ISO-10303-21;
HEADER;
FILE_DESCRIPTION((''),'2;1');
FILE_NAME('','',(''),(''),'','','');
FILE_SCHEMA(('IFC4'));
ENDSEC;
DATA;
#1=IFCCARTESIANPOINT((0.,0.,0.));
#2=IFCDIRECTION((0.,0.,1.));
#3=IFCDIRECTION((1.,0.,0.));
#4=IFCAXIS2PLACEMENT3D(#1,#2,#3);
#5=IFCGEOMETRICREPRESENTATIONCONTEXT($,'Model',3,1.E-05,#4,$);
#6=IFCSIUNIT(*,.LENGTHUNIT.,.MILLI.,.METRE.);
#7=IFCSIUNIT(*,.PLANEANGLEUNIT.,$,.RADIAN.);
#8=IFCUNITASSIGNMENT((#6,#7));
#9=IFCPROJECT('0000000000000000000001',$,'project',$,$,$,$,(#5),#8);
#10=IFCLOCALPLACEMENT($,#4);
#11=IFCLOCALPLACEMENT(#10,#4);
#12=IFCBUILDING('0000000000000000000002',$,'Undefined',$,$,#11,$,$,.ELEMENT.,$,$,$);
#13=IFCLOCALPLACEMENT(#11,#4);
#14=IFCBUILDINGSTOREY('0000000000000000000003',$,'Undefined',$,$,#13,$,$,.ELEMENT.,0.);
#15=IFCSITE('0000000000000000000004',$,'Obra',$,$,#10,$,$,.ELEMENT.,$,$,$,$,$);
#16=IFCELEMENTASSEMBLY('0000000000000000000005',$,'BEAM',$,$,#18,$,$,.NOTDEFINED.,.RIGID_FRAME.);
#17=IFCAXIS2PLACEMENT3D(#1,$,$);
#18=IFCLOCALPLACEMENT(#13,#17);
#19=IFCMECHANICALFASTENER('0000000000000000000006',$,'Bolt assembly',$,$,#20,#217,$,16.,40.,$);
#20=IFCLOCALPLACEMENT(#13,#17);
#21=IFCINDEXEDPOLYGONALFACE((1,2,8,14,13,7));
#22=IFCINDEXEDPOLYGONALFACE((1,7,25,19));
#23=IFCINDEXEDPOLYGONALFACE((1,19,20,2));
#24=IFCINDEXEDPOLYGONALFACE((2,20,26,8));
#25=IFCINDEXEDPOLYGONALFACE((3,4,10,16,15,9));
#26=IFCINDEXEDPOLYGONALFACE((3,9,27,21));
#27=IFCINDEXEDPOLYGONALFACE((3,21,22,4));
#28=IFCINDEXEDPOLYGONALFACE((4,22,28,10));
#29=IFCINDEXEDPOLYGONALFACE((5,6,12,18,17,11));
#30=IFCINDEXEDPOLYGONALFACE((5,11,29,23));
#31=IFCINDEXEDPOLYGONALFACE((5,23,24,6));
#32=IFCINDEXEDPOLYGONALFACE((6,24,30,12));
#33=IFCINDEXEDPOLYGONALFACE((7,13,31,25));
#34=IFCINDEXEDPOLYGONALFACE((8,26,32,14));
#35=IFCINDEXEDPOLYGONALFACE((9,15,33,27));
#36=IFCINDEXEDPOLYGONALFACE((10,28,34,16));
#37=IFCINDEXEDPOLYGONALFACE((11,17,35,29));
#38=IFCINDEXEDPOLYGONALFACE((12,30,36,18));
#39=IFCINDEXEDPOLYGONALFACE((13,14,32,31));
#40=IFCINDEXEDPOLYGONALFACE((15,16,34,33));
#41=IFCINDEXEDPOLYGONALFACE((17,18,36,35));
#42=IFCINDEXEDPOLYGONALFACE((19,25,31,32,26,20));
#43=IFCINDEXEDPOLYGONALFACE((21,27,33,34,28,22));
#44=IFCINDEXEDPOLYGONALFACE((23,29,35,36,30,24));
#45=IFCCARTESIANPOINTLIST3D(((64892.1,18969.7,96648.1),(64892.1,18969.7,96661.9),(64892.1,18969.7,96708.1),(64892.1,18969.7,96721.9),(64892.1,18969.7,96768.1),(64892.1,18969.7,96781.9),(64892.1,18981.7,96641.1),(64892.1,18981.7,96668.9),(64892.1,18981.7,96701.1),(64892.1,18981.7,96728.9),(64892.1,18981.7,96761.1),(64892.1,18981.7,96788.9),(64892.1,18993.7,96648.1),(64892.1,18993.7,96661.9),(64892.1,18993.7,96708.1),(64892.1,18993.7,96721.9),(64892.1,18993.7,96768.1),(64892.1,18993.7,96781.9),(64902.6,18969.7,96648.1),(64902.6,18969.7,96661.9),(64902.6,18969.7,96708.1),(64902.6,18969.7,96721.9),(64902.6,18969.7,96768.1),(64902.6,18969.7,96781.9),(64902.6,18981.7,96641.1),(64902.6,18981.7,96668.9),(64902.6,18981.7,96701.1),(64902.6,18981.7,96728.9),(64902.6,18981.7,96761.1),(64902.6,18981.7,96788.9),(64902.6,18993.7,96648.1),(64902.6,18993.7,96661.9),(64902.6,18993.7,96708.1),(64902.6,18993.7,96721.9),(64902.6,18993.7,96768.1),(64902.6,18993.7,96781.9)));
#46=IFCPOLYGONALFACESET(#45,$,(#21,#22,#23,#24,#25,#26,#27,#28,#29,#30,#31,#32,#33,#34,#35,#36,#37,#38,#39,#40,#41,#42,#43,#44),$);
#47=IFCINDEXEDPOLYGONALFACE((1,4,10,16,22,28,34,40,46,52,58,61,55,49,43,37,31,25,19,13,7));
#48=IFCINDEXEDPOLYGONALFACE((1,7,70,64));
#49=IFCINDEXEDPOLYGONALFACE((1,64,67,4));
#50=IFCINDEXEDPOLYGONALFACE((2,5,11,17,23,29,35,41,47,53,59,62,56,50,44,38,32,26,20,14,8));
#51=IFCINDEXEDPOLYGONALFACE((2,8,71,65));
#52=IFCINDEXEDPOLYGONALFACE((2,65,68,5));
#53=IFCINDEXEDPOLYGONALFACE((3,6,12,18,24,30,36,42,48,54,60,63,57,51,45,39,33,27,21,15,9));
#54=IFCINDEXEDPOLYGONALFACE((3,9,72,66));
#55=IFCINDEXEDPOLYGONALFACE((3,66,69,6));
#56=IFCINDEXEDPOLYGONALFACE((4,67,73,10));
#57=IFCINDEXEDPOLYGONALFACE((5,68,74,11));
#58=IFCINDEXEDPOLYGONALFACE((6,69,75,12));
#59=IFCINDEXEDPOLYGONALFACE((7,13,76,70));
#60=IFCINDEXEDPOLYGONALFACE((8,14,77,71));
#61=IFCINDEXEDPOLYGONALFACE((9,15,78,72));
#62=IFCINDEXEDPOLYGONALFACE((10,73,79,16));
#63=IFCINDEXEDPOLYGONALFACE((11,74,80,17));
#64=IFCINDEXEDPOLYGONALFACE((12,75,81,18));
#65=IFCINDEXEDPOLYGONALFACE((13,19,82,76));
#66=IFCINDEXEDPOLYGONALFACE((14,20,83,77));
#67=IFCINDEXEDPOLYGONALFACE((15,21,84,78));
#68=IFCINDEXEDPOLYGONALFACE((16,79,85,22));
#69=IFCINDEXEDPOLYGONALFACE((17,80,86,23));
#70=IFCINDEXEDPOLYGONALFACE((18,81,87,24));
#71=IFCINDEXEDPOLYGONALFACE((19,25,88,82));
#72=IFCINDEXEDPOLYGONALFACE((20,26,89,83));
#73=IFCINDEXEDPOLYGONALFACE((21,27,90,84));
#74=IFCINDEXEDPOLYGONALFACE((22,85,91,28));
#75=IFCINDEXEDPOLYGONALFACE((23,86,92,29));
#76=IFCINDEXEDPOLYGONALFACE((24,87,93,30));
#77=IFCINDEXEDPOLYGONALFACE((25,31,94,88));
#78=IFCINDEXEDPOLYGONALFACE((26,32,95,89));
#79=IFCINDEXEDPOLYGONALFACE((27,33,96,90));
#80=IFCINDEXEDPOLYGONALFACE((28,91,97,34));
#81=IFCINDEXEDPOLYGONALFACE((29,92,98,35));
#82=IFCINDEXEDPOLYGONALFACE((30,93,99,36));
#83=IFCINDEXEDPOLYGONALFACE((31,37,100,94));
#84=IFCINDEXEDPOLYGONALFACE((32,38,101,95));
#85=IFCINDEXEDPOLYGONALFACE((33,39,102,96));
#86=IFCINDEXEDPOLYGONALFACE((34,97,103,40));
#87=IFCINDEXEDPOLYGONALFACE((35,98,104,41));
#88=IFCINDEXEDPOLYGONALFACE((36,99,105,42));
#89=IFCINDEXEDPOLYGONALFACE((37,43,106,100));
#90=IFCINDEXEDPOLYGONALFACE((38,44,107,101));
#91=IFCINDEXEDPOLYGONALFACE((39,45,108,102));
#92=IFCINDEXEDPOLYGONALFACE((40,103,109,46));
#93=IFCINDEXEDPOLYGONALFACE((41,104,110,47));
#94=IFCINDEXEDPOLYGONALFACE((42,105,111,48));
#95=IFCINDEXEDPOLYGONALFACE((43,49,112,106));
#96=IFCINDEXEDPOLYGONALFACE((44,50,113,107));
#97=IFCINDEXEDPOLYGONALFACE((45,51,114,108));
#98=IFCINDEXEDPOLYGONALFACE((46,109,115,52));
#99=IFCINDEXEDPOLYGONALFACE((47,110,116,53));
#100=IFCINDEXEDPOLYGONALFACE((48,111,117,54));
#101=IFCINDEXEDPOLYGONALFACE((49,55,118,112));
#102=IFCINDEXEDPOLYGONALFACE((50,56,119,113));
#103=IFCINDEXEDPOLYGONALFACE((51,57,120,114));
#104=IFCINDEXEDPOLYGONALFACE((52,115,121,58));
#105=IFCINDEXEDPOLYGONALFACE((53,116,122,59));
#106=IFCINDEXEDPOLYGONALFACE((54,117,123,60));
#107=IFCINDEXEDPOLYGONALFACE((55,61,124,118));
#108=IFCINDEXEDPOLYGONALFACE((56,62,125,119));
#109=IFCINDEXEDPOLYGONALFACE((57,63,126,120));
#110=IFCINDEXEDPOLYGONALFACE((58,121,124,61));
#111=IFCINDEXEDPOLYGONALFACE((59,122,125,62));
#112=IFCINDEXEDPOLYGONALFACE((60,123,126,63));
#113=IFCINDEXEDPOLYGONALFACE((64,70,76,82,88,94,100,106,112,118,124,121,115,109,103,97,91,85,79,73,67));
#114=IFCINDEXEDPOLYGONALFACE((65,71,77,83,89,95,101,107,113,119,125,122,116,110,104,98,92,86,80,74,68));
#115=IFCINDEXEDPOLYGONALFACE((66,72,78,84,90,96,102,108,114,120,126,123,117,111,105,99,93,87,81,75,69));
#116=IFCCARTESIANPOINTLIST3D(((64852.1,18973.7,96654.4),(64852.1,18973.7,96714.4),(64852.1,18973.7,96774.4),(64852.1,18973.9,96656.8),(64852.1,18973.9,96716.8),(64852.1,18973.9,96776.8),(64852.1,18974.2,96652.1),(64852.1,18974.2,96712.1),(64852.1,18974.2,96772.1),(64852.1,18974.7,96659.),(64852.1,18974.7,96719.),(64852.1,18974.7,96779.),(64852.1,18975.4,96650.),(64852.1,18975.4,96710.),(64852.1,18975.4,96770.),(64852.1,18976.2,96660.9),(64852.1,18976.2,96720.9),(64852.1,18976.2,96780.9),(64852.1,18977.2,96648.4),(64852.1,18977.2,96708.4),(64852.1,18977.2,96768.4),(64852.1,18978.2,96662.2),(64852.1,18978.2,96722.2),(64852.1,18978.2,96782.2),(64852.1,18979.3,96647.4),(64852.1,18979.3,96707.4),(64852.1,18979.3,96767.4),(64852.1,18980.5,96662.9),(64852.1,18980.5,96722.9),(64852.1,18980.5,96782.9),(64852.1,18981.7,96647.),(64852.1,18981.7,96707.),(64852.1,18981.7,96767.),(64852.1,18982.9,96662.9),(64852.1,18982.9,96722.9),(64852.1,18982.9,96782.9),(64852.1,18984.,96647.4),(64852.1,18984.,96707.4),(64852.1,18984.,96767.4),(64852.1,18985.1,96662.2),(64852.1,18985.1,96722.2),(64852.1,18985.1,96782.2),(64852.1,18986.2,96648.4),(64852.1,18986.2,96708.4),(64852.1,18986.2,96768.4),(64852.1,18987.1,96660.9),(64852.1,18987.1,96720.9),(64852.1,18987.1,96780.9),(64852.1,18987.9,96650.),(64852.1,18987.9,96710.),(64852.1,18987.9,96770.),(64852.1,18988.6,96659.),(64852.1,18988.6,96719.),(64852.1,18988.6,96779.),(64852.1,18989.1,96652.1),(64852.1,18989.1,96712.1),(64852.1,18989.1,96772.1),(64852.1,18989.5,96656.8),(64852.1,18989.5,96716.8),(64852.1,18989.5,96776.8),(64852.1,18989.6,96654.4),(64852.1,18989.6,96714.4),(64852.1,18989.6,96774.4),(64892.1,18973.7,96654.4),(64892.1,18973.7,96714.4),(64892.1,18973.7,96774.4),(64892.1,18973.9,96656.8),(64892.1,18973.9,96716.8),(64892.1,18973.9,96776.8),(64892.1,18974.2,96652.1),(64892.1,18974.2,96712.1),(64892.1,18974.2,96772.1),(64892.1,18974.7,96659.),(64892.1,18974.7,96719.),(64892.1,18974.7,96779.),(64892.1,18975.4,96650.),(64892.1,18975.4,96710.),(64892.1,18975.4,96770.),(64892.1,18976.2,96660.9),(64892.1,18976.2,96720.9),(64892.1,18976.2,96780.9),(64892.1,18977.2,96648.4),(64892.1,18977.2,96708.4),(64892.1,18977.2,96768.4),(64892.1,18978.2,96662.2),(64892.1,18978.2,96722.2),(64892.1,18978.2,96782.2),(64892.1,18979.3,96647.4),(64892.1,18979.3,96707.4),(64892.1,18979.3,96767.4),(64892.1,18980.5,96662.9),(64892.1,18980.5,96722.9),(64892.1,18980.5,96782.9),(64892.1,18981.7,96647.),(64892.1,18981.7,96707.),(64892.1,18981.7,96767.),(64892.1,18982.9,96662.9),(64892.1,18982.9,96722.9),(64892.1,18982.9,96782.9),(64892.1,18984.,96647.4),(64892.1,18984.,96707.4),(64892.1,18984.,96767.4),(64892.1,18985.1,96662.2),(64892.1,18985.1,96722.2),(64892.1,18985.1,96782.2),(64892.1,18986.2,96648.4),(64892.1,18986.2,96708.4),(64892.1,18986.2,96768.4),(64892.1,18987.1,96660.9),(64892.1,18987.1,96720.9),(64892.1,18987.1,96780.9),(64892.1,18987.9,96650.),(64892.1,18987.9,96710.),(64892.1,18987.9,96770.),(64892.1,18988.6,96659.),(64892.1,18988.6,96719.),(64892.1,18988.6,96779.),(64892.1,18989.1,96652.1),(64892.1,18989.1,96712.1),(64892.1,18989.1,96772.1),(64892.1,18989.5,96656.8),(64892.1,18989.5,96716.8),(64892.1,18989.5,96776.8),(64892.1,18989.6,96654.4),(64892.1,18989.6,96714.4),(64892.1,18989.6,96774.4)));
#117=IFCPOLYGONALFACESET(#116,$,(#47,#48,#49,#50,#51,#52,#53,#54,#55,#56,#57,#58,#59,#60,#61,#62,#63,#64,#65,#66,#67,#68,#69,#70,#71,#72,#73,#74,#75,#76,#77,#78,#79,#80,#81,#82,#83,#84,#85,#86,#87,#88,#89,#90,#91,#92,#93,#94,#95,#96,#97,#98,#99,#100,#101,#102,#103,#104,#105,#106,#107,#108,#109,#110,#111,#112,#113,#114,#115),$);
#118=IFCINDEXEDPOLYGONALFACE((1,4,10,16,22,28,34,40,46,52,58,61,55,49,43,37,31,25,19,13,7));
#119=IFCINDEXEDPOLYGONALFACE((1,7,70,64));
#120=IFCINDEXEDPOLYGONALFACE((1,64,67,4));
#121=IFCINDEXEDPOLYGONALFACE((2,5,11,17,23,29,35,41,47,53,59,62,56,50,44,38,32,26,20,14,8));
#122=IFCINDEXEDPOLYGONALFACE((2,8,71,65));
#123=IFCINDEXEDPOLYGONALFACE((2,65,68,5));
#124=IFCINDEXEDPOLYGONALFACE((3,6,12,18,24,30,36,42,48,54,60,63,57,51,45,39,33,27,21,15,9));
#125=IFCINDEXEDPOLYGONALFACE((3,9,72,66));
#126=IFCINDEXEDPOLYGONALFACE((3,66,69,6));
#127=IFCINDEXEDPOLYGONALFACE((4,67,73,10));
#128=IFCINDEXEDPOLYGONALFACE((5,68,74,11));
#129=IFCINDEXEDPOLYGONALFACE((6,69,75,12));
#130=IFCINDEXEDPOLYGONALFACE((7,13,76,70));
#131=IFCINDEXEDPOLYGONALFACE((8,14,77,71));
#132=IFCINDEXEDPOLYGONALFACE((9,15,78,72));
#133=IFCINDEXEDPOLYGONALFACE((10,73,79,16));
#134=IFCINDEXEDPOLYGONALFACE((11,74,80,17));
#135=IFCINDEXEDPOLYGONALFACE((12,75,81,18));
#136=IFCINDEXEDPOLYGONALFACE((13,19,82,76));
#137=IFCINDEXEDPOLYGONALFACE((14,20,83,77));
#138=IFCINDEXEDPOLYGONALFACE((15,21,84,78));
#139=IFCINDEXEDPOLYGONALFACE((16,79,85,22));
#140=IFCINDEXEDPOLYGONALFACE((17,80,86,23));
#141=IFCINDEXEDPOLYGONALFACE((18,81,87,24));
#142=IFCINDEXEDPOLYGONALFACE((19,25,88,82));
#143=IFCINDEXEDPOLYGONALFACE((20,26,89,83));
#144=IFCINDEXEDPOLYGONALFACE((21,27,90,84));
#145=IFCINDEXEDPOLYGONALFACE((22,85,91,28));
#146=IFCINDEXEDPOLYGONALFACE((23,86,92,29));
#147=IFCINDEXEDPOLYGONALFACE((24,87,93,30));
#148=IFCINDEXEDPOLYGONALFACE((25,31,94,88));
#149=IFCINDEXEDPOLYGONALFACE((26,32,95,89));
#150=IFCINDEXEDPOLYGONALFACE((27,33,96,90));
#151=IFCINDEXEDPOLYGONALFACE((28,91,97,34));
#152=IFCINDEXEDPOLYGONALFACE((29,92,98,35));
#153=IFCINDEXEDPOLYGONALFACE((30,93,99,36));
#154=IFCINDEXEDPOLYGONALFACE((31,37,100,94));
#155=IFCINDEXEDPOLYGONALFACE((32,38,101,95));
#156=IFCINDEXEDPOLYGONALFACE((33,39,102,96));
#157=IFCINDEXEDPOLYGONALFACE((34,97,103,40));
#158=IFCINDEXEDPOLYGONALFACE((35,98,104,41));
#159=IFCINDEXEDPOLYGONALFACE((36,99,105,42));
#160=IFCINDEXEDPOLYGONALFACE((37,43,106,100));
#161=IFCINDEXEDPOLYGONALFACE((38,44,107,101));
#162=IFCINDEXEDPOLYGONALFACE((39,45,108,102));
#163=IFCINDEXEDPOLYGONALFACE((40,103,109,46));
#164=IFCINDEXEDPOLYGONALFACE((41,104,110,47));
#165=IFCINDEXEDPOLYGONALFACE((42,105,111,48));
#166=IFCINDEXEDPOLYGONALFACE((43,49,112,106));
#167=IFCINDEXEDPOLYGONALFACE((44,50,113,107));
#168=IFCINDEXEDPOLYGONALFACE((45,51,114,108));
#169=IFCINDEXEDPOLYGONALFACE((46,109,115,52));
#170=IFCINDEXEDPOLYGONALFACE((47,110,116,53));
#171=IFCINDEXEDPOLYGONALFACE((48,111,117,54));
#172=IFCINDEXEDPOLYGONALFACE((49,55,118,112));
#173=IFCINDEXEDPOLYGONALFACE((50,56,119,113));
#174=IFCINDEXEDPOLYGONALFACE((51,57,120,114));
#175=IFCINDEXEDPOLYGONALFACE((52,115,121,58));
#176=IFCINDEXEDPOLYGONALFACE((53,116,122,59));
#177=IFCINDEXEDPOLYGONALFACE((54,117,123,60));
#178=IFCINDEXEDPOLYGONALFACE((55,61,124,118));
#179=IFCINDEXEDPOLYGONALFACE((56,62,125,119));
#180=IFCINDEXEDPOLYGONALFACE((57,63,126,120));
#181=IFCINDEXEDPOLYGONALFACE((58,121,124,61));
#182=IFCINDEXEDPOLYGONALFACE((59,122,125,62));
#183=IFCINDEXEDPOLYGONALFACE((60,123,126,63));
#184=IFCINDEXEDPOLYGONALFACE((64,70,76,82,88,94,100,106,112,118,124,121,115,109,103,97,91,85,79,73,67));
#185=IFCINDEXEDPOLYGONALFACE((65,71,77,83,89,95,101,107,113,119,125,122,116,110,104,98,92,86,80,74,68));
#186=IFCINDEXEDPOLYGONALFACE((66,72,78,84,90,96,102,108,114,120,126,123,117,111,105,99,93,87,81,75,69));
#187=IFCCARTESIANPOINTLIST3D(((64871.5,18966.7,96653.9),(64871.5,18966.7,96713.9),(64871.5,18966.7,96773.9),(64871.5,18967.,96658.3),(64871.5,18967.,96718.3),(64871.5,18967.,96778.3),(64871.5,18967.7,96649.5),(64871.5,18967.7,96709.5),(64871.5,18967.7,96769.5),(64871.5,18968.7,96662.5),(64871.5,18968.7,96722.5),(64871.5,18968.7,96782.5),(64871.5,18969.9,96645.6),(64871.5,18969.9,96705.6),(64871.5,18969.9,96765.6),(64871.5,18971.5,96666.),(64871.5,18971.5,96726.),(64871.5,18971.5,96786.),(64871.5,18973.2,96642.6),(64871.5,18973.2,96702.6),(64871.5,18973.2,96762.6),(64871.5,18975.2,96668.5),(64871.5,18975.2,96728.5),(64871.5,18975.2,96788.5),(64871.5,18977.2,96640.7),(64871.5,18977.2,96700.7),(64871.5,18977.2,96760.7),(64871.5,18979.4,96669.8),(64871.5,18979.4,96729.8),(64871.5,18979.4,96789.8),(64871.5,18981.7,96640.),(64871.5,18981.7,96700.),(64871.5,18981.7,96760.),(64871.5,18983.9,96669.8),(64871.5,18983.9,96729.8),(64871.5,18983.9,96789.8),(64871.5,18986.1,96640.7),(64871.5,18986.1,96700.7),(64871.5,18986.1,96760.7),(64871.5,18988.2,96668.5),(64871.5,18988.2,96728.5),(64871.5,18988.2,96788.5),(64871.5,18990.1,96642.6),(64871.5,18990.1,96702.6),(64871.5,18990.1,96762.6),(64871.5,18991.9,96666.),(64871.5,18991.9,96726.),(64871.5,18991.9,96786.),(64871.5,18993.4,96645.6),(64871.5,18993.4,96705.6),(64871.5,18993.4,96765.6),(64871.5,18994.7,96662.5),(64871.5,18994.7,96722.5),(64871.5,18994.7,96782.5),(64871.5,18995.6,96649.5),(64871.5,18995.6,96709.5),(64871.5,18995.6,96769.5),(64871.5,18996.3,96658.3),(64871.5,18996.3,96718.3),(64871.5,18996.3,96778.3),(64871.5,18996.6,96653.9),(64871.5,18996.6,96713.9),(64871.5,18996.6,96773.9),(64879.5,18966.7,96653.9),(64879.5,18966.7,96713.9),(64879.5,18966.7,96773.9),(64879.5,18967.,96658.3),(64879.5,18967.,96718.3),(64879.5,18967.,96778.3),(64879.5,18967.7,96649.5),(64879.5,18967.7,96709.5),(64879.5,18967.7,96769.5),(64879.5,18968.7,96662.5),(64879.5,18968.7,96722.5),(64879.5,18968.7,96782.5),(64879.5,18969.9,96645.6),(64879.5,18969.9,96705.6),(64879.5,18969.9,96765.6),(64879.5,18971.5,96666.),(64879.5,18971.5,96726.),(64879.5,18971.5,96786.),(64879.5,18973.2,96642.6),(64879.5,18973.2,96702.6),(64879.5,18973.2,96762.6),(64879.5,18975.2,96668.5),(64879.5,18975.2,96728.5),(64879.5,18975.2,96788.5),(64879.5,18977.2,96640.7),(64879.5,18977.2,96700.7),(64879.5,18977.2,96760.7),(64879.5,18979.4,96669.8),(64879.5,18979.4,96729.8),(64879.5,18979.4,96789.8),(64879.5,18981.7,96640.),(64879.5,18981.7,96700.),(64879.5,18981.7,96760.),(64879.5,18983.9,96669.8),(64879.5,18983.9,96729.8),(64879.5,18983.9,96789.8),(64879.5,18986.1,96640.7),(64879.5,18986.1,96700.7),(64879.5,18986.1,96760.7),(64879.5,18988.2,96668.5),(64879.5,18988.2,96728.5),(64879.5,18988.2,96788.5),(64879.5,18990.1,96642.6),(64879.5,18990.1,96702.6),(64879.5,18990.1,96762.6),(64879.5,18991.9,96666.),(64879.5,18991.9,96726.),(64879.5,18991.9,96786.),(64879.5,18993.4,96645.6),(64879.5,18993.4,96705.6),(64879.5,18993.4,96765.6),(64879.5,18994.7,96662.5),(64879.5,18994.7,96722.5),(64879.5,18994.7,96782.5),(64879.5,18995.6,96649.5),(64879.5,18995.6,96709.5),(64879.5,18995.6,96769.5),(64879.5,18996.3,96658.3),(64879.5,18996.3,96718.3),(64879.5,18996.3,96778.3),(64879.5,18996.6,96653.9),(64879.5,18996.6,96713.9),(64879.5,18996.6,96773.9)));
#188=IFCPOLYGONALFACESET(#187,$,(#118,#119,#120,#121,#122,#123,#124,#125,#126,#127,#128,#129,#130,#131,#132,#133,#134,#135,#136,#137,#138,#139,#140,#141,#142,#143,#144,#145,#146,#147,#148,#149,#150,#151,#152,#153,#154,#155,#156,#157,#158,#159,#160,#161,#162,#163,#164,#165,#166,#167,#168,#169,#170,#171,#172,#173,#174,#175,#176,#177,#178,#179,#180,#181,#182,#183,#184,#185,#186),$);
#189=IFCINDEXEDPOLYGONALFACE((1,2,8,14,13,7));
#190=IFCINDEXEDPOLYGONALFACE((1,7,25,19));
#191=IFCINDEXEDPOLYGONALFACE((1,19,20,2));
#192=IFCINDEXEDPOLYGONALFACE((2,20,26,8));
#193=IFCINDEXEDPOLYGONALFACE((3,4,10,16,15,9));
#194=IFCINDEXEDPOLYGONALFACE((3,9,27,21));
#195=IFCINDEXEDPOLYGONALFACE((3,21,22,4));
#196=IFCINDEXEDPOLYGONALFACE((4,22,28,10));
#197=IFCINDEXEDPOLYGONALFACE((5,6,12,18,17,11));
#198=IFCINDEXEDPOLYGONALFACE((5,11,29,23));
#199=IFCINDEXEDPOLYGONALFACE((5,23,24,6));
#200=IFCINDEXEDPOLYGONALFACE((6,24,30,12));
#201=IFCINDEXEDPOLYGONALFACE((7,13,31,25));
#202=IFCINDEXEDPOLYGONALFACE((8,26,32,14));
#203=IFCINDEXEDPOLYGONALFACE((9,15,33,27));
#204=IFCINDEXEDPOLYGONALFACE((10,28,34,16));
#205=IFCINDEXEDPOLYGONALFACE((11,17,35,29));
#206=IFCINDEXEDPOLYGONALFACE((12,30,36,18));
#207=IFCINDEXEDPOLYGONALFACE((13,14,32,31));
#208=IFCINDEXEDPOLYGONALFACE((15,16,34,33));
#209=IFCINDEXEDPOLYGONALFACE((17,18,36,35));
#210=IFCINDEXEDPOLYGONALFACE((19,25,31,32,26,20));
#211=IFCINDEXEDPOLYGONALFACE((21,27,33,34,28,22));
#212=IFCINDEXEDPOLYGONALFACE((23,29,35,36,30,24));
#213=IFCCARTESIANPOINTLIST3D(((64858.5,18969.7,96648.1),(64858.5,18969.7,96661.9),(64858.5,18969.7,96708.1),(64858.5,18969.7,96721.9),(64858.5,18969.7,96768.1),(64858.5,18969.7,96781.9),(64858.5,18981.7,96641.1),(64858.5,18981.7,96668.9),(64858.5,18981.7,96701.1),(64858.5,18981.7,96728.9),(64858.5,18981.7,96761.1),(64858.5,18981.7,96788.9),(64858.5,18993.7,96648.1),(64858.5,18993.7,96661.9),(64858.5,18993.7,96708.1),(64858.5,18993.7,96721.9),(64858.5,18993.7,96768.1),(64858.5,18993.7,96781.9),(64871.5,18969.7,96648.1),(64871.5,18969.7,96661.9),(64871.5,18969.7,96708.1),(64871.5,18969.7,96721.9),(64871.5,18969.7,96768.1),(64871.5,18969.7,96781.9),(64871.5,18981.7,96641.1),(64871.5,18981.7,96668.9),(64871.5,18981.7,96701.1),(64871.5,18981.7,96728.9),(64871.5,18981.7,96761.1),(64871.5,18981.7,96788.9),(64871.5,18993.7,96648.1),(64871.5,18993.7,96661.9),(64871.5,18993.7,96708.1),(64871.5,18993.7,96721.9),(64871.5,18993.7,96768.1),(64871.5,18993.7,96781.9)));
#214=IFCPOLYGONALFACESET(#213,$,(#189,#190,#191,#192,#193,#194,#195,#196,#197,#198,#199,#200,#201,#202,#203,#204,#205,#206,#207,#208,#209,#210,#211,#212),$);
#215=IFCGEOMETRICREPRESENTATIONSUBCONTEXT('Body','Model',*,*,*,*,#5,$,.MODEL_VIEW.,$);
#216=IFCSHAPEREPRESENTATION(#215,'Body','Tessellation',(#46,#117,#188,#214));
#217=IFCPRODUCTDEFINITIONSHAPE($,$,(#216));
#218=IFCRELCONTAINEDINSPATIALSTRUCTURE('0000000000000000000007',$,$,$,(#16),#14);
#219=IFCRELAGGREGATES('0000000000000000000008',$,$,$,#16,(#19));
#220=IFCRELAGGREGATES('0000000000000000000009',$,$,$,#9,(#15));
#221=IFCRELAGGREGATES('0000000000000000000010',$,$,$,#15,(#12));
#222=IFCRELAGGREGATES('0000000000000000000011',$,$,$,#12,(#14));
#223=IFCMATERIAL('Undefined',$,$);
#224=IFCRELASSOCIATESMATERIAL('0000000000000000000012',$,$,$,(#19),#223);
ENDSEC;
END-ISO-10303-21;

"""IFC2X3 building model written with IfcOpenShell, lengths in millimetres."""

from ifc_helpers import new_model, si_unit, frame, origin_with_axes, origin_2d_with_axis, place, context, subcontext, project, spatial, polyline, circle, outline, extrude, source, transform, mapped, material, element, aggregate, save


model = new_model("IFC2X3")

# Units and contexts
model_context = context("Model", 3, precision=1e-05, world=origin_with_axes())
body_context = subcontext(model_context, "Body", "Model", "MODEL_VIEW")
ifc_project = project(units=[si_unit("LENGTHUNIT", "METRE", prefix="MILLI"), si_unit("PLANEANGLEUNIT", "RADIAN")], contexts=[model_context])

# Site, building, storey
site_placement = place(None, origin_with_axes())
site = spatial("IfcSite", under=ifc_project, at=site_placement, Name="Obra", CompositionType="ELEMENT")
building_placement = place(site_placement, origin_with_axes())
building = spatial("IfcBuilding", under=site, at=building_placement, Name="Undefined", CompositionType="ELEMENT")
storey_placement = place(building_placement, origin_with_axes())
storey = spatial("IfcBuildingStorey", under=building, at=storey_placement, Name="Undefined", CompositionType="ELEMENT", Elevation=0.0)

# Element assembly, mechanical fastener
assembly_1_placement = place(storey_placement, origin_with_axes())
assembly_1 = element("IfcElementAssembly", 1, at=assembly_1_placement, inside=storey, Name="BEAM", AssemblyPlace="NOTDEFINED", PredefinedType="RIGID_FRAME")
ifc_material_1 = material(Name="Undefined")
shared_shape_1 = source(origin_with_axes(), body_context, "Body", "SweptSolid", [
    extrude(outline(polyline([(13.9, 0.0), (6.9, 12.0), (-6.9, 12.0), (-13.9, 0.0), (-6.9, -12.0), (6.9, -12.0), (13.9, 0.0)])), frame((0.0, -19.9, 0.0), z_axis=(0.0, 1.0, 0.0), x_axis=(1.0, 0.0, 0.0)), (0.0, 0.0, 1.0), 10.6),
    extrude(circle(Radius=8.0, at=origin_2d_with_axis()), frame((0.0, -9.3, 0.0), z_axis=(0.0, 1.0, 0.0), x_axis=(1.0, 0.0, 0.0)), (0.0, 0.0, 1.0), 40.0),
    extrude(circle(Radius=15.0, at=origin_2d_with_axis()), frame((0.0, 3.3, 0.0), z_axis=(0.0, 1.0, 0.0), x_axis=(1.0, 0.0, 0.0)), (0.0, 0.0, 1.0), 8.0),
    extrude(outline(polyline([(13.9, 0.0), (6.9, 12.0), (-6.9, 12.0), (-13.9, 0.0), (-6.9, -12.0), (6.9, -12.0), (13.9, 0.0)])), frame((0.0, 11.3, 0.0), z_axis=(0.0, 1.0, 0.0), x_axis=(1.0, 0.0, 0.0)), (0.0, 0.0, 1.0), 13.0),
])
mechanical_fastener_1_placement = place(assembly_1_placement, frame((64882.8, 18931.7, 96850.0), z_axis=(-0.000002, 1.0, 0.0), x_axis=(0.0, 0.0, -1.0)))
mechanical_fastener_1 = element("IfcMechanicalFastener", 2, at=mechanical_fastener_1_placement, material=ifc_material_1, Name="Bolt assembly", NominalDiameter=16.0, NominalLength=40.0, context=body_context, shape_type="MappedRepresentation", body=[
    mapped(shared_shape_1, transform((75.0, 0.0, 50.0))),
    mapped(shared_shape_1, transform((135.0, 0.0, 50.0))),
    mapped(shared_shape_1, transform((195.0, 0.0, 50.0))),
])
aggregate(assembly_1, [mechanical_fastener_1])

save(model, "model.ifc")
